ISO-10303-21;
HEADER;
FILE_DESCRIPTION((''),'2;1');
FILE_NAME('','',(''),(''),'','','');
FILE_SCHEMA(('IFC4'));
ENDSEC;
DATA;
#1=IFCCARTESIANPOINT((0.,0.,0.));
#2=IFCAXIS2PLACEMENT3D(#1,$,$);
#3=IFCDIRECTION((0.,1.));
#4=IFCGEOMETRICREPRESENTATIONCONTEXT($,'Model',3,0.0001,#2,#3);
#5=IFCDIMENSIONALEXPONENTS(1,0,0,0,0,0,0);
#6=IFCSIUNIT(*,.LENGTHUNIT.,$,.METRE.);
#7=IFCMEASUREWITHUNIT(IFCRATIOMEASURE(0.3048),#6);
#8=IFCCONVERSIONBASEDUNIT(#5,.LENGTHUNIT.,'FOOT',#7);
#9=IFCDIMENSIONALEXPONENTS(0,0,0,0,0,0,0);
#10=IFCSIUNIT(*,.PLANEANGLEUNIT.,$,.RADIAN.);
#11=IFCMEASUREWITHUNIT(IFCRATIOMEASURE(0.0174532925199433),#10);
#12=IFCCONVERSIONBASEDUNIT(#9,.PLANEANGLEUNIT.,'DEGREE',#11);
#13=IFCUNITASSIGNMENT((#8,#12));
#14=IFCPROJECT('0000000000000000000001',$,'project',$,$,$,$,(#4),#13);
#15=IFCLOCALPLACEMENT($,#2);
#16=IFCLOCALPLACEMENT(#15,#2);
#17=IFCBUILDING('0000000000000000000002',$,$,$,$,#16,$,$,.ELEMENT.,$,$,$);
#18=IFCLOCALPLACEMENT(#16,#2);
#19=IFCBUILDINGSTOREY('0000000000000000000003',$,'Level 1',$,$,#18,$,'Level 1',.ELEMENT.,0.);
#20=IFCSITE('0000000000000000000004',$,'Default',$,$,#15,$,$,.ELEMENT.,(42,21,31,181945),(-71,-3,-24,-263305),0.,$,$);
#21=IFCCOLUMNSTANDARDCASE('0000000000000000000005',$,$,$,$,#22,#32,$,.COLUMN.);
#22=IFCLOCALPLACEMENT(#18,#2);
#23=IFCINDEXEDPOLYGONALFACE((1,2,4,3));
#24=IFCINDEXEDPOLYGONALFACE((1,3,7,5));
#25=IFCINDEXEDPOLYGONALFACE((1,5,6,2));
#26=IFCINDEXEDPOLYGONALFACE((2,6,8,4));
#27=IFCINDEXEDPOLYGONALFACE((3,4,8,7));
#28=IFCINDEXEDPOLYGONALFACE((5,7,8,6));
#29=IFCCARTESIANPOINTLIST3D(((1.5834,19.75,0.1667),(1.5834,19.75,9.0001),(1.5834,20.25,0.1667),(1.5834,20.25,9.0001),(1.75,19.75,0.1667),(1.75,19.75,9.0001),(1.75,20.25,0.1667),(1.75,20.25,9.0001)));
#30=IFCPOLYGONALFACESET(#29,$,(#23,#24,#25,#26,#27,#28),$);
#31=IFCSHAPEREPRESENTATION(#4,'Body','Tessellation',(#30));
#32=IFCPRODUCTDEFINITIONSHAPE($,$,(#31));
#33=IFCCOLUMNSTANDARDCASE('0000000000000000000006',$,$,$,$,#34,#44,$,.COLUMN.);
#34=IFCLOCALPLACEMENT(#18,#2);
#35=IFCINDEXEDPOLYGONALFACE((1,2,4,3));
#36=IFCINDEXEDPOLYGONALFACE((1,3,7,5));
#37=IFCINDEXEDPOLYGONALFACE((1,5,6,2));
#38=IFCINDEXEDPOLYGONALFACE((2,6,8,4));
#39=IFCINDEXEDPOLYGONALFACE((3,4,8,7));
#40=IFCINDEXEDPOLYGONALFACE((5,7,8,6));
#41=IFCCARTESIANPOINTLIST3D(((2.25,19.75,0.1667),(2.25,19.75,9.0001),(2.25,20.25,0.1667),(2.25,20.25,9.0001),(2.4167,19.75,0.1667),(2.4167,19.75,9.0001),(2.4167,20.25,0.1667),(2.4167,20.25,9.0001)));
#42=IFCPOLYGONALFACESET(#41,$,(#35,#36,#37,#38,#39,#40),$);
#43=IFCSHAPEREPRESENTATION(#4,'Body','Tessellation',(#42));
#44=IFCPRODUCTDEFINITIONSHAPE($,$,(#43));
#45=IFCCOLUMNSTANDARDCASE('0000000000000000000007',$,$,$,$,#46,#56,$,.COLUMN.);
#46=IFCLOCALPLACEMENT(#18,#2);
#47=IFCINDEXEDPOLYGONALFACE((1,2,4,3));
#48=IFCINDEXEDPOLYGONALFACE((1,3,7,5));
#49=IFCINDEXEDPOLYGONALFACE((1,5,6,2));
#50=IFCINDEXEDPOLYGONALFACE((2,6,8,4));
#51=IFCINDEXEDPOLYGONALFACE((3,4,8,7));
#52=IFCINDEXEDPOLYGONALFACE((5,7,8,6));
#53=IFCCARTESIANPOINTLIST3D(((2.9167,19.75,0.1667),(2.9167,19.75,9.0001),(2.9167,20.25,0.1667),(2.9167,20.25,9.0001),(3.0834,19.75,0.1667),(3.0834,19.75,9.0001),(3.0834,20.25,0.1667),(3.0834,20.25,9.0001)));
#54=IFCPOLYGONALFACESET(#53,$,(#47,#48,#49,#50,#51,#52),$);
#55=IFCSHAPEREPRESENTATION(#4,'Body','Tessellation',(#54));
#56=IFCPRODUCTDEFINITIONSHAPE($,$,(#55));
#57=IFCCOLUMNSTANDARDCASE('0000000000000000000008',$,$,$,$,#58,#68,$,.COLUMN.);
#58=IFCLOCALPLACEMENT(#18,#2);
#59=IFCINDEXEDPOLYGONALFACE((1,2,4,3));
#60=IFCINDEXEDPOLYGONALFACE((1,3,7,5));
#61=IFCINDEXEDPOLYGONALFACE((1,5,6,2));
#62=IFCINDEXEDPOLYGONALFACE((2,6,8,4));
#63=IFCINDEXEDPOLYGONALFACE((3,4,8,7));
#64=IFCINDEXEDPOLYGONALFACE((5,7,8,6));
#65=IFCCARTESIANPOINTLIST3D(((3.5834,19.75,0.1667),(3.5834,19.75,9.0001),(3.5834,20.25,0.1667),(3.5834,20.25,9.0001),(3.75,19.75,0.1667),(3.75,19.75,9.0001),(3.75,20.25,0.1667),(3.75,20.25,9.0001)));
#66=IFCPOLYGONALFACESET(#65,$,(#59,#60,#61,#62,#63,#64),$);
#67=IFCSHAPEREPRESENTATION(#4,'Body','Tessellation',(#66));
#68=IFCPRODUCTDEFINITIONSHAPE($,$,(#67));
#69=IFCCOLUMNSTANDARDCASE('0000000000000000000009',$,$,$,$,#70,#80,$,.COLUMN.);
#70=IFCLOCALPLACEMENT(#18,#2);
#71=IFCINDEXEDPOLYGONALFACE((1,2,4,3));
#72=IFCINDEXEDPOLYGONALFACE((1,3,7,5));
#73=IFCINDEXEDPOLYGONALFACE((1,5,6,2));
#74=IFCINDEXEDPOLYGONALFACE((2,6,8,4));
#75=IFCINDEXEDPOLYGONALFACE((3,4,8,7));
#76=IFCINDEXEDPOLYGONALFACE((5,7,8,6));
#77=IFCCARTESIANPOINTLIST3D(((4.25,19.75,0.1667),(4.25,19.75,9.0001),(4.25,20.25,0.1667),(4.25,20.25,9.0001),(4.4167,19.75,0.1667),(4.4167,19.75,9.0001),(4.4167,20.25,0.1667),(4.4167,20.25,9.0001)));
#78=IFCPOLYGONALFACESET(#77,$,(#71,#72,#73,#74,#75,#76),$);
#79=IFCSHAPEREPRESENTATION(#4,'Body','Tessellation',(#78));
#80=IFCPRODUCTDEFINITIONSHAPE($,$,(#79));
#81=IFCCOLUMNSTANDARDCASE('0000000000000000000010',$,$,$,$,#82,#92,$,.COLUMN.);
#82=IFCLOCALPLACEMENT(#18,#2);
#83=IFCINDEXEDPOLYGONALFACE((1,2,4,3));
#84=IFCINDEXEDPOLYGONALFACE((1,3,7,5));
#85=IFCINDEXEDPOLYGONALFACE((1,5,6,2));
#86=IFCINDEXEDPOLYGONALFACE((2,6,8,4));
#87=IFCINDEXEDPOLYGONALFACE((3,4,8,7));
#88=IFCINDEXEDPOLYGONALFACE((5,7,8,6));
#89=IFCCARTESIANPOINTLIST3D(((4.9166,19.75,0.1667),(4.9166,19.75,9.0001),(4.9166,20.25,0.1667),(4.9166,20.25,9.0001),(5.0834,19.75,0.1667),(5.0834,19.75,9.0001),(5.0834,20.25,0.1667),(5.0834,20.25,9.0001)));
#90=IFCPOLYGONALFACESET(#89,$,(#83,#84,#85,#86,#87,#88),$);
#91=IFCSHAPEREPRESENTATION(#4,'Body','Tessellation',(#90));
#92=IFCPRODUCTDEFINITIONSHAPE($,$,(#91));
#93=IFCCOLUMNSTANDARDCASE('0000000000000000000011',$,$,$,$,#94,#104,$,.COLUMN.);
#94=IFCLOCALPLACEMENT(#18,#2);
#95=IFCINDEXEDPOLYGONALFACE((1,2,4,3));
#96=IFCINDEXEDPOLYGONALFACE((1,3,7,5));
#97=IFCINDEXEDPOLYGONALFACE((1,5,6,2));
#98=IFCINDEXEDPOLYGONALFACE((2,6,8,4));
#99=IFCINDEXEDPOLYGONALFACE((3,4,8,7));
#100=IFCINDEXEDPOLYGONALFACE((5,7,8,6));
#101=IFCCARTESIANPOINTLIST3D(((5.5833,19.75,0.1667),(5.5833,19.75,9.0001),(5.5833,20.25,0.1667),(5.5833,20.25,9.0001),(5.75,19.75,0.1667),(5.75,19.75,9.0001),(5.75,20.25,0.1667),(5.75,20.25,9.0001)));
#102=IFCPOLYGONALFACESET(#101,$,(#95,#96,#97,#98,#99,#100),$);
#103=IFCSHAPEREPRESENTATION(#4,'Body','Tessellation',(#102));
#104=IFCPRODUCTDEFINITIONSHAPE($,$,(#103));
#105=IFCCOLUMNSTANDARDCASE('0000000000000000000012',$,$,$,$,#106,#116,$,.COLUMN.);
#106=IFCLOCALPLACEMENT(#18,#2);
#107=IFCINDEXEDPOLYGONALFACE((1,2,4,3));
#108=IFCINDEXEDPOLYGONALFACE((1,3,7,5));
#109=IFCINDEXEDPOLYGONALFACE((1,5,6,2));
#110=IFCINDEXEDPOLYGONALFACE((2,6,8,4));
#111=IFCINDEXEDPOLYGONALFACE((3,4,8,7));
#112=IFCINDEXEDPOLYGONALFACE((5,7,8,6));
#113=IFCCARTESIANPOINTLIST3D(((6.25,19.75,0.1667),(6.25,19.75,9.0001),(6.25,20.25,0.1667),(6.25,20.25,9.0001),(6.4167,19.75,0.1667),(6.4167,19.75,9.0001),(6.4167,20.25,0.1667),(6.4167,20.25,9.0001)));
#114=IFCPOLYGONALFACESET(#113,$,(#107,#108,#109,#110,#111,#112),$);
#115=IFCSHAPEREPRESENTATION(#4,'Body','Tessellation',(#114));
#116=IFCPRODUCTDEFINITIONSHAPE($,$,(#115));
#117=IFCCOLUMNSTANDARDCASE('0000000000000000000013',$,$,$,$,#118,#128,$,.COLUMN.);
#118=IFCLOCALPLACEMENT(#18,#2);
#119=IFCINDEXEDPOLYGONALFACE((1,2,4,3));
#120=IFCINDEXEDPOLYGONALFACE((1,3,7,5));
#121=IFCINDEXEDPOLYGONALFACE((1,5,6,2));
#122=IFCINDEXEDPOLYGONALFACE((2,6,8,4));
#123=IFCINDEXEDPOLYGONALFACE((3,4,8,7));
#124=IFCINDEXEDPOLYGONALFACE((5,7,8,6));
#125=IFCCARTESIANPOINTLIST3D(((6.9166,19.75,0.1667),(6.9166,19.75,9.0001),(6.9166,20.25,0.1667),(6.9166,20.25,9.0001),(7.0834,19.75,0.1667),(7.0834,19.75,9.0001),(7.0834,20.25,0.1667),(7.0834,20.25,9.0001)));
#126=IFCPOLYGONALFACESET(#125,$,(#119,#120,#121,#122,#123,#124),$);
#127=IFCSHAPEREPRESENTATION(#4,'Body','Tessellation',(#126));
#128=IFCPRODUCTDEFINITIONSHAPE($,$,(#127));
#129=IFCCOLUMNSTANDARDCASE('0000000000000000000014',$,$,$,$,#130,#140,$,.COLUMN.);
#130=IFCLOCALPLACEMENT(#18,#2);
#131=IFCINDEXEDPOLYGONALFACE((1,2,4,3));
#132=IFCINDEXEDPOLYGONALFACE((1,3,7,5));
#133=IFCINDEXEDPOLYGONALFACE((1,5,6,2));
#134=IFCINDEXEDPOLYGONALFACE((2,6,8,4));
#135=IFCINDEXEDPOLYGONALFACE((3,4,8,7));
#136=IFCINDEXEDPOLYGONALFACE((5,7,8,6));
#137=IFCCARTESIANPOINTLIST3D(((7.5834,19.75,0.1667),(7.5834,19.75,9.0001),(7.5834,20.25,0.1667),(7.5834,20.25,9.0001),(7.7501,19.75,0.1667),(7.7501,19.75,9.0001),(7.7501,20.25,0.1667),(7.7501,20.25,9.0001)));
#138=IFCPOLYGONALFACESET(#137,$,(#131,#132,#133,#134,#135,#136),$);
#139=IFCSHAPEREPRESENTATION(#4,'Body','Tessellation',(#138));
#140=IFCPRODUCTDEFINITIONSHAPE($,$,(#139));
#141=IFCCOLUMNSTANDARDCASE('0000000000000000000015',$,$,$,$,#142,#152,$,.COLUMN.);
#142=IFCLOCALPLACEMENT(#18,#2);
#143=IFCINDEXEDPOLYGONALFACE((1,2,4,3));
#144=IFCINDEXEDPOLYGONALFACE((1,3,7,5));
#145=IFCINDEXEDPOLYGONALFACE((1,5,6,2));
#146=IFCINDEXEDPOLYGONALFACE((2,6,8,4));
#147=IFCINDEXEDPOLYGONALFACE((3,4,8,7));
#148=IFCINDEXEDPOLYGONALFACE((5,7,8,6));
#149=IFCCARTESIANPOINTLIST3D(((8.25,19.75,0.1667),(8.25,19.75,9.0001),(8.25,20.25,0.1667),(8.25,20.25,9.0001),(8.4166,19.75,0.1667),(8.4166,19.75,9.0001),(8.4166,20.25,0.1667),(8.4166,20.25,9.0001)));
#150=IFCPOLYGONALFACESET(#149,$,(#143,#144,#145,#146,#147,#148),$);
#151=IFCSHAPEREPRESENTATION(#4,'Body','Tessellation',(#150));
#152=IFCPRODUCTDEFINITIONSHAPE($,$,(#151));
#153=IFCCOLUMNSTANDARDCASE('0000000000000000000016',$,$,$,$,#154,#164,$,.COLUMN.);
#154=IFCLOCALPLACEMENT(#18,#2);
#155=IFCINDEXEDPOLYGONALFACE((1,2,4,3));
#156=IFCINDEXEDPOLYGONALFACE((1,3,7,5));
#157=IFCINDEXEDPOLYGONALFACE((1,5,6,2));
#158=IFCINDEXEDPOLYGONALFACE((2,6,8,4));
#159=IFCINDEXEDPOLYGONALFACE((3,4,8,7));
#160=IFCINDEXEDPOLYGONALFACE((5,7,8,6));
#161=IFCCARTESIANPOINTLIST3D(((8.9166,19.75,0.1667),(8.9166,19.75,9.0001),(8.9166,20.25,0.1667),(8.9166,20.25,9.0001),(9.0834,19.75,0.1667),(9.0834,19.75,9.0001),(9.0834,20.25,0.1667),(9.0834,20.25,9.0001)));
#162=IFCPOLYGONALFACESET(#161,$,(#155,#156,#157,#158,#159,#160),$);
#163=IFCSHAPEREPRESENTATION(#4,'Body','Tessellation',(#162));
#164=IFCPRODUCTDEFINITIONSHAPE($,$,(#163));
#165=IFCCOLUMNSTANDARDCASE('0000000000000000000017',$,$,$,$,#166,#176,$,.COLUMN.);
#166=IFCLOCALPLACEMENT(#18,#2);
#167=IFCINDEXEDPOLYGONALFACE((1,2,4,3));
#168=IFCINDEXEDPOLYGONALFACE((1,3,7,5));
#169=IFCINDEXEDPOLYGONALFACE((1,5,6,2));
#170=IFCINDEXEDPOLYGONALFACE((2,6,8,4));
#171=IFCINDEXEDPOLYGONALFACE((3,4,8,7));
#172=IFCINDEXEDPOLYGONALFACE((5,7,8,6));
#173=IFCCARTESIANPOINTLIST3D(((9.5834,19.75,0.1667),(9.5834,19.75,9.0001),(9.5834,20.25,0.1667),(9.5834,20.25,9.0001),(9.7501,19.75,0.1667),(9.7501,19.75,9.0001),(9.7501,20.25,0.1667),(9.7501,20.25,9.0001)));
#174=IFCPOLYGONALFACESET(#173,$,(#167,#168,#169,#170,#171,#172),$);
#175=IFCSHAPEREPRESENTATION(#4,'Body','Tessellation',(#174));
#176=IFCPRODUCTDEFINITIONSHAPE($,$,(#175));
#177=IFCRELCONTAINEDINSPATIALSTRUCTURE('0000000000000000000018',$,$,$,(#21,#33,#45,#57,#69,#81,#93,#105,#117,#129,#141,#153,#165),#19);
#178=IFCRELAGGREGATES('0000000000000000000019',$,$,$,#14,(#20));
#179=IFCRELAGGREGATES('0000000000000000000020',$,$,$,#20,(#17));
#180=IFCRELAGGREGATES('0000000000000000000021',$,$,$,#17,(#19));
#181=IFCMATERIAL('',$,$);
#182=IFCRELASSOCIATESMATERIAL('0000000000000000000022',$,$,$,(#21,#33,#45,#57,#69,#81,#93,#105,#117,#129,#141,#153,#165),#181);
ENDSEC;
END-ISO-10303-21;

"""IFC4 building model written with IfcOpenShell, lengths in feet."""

from ifc_helpers import new_model, entity, si_unit, converted_unit, direction, frame, origin, place, context, project, spatial, rectangle, extrude, material, element, save


model = new_model("IFC4")

# Units and contexts
model_context = context("Model", 3, precision=0.0001, world=origin(), true_north=direction((0.0, 1.0)))
ifc_project = project(units=[converted_unit("LENGTHUNIT", "FOOT", entity("IfcRatioMeasure", 0.3048), si_unit("LENGTHUNIT", "METRE"), dimensions=[1, 0, 0, 0, 0, 0, 0]), converted_unit("PLANEANGLEUNIT", "DEGREE", entity("IfcRatioMeasure", 0.0174532925199433), si_unit("PLANEANGLEUNIT", "RADIAN"), dimensions=[0, 0, 0, 0, 0, 0, 0])], contexts=[model_context])

# Site, building, storey
site_placement = place(None, origin())
site = spatial("IfcSite", under=ifc_project, at=site_placement, Name="Default", CompositionType="ELEMENT", RefLatitude=(42, 21, 31, 181945), RefLongitude=(-71, -3, -24, -263305), RefElevation=0.0)
building_placement = place(site_placement, origin())
building = spatial("IfcBuilding", under=site, at=building_placement, CompositionType="ELEMENT")
storey_placement = place(building_placement, origin())
storey = spatial("IfcBuildingStorey", under=building, at=storey_placement, Name="Level 1", LongName="Level 1", CompositionType="ELEMENT", Elevation=0.0)

# Columns
ifc_material_1 = material(Name="")
placement_1 = place(storey_placement, frame((0.25, 20.0, 0.0)))
for number, where, z_axis, x_axis in (
    (1, (1.4167, 0.0, 0.1667), (0.0, 0.0, 1.0), (1.0, 0.0, 0.0)),
    (2, (2.0833, 0.0, 0.1667), (0.0, 0.0, 1.0), (1.0, 0.0, 0.0)),
    (3, (2.75, 0.0, 0.1667), (0.0, 0.0, 1.0), (1.0, 0.0, 0.0)),
    (4, (3.4167, 0.0, 0.1667), (0.0, 0.0, 1.0), (1.0, 0.0, 0.0)),
    (5, (4.0833, 0.0, 0.1667), (0.0, 0.0, 1.0), (1.0, 0.0, 0.0)),
    (6, (4.75, 0.0, 0.1667), (0.0, 0.0, 1.0), (1.0, 0.0, 0.0)),
    (7, (5.4167, 0.0, 0.1667), (0.0, 0.0, 1.0), (1.0, 0.0, 0.0)),
    (8, (6.0833, 0.0, 0.1667), (0.0, 0.0, 1.0), (1.0, 0.0, 0.0)),
    (9, (6.75, 0.0, 0.1667), (0.0, 0.0, 1.0), (1.0, 0.0, 0.0)),
    (10, (7.4167, 0.0, 0.1667), (0.0, 0.0, 1.0), (1.0, 0.0, 0.0)),
    (11, (8.0833, 0.0, 0.1667), (0.0, 0.0, 1.0), (1.0, 0.0, 0.0)),
    (12, (8.75, 0.0, 0.1667), (0.0, 0.0, 1.0), (1.0, 0.0, 0.0)),
    (13, (9.4167, 0.0, 0.1667), (0.0, 0.0, 1.0), (1.0, 0.0, 0.0)),
):
    element("IfcColumnStandardCase", number, at=place(placement_1, frame(where, z_axis=z_axis, x_axis=x_axis)), inside=storey, material=ifc_material_1, PredefinedType="COLUMN", context=model_context, shape_type="SweptSolid", body=[
        extrude(rectangle(XDim=0.1667, YDim=0.5), origin(), (0.0, 0.0, 1.0), 8.8334),
    ])

save(model, "model.ifc")
